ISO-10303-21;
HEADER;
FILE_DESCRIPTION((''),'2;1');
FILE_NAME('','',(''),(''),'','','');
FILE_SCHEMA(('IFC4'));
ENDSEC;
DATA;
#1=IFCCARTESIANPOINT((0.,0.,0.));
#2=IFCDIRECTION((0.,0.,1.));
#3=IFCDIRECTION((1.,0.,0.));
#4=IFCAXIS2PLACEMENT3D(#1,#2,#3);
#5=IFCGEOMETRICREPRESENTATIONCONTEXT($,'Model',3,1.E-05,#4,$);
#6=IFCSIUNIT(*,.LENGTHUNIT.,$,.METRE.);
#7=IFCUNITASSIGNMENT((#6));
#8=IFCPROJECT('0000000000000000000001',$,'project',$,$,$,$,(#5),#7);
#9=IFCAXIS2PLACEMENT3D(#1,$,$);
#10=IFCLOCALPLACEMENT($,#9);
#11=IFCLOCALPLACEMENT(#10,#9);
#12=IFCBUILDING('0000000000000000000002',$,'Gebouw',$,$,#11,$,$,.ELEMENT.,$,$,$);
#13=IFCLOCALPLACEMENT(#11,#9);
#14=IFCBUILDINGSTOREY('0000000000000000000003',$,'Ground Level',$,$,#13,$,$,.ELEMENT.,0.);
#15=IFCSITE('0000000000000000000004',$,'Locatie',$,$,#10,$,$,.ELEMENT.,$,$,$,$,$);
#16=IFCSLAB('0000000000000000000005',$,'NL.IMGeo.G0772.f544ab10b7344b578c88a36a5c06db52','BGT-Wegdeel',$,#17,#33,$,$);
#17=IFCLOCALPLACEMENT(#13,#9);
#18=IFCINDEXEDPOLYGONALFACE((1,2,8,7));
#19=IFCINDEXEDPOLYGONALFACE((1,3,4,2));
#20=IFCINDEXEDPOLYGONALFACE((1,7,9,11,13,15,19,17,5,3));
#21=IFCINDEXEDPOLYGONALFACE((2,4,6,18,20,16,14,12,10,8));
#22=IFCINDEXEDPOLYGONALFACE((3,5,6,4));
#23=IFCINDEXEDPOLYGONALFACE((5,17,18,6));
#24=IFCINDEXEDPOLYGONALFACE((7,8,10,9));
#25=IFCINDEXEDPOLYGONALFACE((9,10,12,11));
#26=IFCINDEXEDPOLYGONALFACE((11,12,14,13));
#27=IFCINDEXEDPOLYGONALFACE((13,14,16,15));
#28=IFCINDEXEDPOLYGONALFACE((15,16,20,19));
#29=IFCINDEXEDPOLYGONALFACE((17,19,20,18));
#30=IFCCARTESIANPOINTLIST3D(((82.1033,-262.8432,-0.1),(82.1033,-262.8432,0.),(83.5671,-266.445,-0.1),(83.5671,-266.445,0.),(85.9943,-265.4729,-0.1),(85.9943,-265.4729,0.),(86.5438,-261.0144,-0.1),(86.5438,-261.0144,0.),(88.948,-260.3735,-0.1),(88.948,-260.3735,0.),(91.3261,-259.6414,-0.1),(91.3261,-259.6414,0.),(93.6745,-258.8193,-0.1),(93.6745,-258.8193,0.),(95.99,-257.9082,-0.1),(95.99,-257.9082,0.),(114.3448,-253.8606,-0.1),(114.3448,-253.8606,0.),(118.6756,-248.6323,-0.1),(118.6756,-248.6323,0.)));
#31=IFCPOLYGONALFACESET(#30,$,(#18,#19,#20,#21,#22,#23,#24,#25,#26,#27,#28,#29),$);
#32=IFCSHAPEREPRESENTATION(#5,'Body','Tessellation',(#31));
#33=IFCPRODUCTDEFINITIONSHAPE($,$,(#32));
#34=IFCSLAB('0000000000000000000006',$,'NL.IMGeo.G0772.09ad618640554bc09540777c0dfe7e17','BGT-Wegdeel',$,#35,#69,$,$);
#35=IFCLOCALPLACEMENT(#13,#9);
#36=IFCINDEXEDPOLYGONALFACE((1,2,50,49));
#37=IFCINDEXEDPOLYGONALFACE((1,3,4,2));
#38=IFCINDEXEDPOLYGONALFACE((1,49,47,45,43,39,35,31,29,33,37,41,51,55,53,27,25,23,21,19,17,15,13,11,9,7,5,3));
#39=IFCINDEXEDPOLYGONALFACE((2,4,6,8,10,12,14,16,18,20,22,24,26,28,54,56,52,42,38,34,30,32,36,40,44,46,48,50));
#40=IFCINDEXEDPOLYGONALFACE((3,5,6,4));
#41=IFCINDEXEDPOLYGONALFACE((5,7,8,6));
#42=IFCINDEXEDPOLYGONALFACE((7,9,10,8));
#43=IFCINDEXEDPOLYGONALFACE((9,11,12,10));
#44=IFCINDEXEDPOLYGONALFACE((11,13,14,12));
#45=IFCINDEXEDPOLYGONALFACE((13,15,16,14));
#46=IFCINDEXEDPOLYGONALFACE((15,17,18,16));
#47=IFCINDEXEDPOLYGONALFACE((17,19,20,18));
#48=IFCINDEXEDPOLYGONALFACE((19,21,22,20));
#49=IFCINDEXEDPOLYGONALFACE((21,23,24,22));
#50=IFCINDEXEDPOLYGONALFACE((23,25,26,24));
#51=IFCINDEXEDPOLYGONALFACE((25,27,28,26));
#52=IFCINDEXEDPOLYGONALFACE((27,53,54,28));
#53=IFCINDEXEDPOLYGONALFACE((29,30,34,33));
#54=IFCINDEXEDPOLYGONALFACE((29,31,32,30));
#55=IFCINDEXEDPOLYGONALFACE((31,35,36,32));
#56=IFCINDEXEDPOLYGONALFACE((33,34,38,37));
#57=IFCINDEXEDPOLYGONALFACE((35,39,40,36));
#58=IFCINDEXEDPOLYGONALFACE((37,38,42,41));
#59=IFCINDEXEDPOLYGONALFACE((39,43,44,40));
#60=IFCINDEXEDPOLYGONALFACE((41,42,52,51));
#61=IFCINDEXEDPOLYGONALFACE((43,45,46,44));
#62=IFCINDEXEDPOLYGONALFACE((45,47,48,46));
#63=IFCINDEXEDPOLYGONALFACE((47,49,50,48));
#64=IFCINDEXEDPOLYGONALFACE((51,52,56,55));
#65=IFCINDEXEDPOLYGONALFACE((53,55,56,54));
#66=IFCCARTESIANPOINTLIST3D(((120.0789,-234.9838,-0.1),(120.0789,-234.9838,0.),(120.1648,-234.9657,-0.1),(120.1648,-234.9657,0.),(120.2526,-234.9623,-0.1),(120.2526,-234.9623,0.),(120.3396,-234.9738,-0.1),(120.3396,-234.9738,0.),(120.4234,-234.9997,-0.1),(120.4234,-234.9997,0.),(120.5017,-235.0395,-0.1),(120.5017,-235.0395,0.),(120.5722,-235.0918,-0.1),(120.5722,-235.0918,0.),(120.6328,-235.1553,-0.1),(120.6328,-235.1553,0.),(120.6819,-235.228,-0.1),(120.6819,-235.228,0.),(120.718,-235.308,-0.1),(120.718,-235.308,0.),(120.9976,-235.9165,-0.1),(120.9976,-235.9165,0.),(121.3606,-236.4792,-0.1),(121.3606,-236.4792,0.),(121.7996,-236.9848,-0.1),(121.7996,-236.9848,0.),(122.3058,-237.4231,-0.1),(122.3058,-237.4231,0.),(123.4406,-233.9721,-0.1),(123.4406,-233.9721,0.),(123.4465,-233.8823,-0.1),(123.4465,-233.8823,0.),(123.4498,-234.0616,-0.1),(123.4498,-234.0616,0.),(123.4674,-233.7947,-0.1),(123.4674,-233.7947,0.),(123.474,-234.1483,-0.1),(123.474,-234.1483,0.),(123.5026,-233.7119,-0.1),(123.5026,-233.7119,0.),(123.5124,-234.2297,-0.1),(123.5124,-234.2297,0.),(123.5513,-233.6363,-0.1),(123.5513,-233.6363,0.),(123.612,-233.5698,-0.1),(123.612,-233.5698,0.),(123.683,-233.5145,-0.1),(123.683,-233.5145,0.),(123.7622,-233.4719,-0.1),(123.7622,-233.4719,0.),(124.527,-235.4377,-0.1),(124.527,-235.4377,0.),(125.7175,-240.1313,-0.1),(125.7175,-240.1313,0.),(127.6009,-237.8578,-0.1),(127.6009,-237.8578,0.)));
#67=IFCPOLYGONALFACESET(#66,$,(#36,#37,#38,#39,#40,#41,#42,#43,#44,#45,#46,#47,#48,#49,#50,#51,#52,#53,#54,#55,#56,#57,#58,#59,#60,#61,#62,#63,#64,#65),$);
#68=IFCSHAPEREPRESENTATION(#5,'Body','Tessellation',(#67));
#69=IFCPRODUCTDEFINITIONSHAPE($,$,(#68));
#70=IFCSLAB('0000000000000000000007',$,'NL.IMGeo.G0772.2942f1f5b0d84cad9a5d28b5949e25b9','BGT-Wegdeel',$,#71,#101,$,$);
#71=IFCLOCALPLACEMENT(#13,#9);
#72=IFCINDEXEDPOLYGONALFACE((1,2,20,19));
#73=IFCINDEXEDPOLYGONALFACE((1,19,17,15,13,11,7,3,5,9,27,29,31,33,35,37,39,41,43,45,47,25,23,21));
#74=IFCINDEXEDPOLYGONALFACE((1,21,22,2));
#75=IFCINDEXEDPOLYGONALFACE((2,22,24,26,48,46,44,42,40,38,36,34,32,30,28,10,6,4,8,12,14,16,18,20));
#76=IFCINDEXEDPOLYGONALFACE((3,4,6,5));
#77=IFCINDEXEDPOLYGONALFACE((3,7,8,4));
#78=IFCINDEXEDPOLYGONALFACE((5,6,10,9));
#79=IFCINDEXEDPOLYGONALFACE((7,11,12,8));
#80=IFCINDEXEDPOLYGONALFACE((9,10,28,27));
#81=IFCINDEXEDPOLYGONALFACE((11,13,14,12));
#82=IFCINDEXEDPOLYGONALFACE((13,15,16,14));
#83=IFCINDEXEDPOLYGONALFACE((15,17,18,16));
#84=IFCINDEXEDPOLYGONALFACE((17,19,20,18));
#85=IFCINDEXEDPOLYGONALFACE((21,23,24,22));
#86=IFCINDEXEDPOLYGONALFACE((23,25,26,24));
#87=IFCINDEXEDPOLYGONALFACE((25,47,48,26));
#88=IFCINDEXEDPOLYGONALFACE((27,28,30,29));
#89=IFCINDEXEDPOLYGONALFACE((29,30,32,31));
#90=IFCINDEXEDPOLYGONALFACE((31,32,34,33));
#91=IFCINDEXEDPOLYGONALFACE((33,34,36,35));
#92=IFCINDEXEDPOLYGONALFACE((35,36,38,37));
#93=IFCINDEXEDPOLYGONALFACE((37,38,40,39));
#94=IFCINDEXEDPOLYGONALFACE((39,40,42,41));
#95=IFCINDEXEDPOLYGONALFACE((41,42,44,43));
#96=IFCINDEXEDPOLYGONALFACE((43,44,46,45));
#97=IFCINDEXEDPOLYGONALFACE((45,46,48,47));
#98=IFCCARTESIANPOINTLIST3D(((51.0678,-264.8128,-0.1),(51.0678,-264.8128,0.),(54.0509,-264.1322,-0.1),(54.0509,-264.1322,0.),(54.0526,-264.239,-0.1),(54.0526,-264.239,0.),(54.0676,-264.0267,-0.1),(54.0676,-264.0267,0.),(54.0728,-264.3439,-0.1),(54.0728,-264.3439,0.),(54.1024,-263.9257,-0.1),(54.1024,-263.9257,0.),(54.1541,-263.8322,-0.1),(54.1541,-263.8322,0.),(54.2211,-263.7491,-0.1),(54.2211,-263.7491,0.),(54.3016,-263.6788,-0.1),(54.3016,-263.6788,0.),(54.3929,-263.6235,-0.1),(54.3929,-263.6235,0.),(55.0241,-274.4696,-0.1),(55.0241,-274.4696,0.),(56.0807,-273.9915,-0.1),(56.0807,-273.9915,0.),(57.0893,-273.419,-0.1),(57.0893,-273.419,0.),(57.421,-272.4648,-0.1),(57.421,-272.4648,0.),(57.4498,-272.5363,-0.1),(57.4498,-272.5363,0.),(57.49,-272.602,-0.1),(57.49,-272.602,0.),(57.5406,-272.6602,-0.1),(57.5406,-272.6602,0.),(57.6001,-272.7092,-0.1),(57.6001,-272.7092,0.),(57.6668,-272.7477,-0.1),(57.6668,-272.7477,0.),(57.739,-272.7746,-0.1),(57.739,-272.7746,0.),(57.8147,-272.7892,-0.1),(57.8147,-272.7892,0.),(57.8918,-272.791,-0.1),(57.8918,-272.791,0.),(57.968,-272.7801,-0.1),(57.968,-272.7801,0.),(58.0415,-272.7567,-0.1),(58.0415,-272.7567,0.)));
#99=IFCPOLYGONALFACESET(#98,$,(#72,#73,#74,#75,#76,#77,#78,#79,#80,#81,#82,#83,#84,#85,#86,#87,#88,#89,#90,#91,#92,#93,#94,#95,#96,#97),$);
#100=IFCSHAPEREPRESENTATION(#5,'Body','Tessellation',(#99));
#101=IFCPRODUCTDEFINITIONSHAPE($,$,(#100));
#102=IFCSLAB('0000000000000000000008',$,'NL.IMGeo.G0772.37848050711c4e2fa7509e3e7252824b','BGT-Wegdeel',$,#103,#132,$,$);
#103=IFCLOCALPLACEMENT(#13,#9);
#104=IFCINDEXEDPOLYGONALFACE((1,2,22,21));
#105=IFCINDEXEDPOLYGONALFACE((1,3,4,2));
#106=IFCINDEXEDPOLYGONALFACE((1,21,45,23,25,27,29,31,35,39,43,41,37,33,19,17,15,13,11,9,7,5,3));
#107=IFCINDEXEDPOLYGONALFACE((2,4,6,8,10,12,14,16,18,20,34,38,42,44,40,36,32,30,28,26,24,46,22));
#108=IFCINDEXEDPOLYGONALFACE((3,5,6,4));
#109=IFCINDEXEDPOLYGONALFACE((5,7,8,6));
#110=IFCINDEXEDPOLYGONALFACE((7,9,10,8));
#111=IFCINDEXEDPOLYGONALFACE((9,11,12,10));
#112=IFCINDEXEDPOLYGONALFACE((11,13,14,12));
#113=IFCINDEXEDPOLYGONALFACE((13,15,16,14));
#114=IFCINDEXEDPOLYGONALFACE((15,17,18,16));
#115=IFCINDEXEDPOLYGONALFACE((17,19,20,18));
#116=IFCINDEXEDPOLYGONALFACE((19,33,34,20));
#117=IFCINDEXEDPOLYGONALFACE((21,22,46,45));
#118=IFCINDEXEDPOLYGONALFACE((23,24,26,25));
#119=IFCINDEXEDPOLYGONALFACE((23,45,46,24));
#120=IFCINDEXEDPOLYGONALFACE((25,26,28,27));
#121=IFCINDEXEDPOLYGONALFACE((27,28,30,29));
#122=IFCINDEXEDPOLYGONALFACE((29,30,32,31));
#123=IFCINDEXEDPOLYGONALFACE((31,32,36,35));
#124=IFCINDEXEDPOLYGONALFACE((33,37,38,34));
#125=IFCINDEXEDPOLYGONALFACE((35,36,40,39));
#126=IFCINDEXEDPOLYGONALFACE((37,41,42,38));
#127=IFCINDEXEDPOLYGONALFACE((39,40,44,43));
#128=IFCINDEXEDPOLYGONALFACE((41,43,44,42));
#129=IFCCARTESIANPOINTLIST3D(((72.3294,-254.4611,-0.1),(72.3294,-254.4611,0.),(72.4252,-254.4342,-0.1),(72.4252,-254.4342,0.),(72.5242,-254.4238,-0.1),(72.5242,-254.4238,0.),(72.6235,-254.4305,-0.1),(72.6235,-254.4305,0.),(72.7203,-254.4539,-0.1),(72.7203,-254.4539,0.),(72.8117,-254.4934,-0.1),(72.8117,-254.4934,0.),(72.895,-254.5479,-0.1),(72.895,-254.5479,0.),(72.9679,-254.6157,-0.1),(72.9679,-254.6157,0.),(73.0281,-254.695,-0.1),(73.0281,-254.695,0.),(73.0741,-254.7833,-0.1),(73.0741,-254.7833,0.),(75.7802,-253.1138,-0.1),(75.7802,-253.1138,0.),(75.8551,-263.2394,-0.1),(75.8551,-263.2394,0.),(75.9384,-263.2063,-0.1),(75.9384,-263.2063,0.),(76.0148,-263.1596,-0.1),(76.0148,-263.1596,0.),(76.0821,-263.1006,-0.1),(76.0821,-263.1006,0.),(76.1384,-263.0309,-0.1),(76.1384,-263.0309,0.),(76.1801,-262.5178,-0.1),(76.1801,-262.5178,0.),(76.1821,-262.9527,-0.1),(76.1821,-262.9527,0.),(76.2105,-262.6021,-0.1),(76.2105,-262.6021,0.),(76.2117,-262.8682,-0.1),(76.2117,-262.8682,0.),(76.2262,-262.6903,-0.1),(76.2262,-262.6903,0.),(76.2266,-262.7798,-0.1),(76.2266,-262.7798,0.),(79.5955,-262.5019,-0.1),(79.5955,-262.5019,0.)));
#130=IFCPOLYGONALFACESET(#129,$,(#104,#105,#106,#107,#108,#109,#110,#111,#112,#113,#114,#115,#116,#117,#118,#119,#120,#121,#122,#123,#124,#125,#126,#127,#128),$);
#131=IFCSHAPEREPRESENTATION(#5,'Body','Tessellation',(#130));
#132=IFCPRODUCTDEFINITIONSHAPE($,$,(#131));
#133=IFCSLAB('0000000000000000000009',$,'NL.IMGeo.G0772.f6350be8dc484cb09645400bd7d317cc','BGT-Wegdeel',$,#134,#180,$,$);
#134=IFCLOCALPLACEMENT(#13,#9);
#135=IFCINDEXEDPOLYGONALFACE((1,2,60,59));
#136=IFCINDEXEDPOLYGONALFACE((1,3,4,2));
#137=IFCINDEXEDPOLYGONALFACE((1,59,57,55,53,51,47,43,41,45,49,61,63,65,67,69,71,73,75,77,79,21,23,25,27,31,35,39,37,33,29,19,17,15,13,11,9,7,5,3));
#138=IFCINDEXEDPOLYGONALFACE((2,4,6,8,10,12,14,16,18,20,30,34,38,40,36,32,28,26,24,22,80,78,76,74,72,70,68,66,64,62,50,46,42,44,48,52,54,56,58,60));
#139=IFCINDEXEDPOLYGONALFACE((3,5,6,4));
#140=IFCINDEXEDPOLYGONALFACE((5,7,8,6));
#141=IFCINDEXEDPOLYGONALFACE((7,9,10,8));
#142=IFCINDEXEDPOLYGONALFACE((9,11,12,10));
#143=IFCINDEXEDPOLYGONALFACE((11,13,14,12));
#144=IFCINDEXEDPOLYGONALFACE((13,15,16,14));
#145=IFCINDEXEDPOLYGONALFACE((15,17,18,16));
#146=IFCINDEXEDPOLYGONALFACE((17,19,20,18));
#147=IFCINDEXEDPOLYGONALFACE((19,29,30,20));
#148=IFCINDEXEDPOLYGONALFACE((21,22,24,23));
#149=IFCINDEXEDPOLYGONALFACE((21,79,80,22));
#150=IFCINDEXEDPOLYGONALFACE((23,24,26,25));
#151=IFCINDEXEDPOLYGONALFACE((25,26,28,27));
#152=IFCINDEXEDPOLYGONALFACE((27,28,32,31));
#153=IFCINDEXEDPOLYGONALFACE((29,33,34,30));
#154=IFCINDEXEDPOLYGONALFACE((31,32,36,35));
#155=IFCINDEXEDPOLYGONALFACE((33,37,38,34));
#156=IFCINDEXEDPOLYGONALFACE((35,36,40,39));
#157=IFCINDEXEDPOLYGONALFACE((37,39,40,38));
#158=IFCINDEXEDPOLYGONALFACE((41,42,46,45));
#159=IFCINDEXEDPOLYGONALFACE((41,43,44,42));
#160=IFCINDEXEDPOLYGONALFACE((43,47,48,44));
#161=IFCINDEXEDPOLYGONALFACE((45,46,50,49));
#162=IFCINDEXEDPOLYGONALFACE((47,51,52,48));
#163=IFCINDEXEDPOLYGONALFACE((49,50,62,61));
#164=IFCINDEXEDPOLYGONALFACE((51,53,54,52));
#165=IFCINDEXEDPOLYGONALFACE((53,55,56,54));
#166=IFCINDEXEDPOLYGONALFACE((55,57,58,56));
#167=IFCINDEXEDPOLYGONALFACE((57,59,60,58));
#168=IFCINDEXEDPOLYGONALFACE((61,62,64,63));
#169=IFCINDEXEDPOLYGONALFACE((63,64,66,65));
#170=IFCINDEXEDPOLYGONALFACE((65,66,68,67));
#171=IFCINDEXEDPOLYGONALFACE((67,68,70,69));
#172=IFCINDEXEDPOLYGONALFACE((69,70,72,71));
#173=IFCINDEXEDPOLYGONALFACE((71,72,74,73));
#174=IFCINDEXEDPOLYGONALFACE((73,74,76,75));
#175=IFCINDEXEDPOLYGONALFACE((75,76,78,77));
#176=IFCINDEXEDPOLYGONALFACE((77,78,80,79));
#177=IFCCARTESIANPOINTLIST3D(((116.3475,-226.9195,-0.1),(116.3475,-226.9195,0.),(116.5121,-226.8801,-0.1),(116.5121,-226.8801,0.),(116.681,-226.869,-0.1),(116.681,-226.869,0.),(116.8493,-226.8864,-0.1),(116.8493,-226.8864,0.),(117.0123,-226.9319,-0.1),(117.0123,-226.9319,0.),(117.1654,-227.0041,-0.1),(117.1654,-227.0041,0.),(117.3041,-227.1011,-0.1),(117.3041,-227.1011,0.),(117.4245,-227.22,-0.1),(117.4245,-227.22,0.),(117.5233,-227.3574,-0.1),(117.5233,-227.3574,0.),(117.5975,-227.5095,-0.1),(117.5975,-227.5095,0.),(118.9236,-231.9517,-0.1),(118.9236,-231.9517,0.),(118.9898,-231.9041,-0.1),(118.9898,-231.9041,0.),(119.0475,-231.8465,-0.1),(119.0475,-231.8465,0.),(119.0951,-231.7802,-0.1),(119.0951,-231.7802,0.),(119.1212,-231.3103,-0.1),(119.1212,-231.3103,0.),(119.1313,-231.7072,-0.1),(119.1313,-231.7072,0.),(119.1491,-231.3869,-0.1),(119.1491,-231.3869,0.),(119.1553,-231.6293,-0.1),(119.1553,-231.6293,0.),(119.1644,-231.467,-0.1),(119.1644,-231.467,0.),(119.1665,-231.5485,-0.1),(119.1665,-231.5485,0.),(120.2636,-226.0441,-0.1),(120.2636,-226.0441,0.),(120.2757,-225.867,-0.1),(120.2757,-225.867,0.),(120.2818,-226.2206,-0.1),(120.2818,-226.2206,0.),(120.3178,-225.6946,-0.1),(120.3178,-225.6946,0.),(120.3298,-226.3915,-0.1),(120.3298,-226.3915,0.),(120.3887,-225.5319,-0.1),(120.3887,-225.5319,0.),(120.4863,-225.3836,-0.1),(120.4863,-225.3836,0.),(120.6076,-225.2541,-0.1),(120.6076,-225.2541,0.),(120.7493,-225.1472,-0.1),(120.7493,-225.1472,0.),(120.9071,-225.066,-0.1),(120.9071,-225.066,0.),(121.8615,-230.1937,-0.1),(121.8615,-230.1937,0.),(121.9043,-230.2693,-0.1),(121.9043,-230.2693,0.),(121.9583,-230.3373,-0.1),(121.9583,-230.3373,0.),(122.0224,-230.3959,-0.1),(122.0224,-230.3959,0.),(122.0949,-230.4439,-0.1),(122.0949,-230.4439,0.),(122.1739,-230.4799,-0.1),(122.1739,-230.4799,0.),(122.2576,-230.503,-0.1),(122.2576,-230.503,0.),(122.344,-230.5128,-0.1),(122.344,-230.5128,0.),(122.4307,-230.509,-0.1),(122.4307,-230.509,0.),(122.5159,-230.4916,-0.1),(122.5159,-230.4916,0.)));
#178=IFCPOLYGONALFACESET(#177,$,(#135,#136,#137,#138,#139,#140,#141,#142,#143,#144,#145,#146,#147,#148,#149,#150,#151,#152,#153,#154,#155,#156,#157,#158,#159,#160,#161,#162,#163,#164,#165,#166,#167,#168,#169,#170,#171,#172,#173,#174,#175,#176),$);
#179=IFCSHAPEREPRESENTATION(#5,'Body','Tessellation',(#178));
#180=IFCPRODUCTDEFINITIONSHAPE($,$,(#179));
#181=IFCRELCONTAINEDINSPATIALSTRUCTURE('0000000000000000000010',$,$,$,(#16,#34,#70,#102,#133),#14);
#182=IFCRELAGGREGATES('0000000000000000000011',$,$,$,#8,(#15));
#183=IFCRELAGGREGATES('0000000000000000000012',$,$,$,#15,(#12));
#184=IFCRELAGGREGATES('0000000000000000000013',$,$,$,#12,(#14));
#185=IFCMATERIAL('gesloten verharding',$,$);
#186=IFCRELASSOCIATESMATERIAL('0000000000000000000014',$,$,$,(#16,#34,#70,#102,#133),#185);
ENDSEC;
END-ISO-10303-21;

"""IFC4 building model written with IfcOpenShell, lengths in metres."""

from ifc_helpers import new_model, si_unit, frame, origin, origin_with_axes, place, context, project, spatial, polyline, outline, extrude, material, element, save


model = new_model("IFC4")

# Units and contexts
model_context = context("Model", 3, precision=1e-05, world=origin_with_axes())
ifc_project = project(units=[si_unit("LENGTHUNIT", "METRE")], contexts=[model_context])

# Site, building, storey
site_placement = place(None, origin())
site = spatial("IfcSite", under=ifc_project, at=site_placement, Name="Locatie", CompositionType="ELEMENT")
building_placement = place(site_placement, origin())
building = spatial("IfcBuilding", under=site, at=building_placement, Name="Gebouw", CompositionType="ELEMENT")
storey_placement = place(building_placement, origin())
storey = spatial("IfcBuildingStorey", under=building, at=storey_placement, Name="Ground Level", CompositionType="ELEMENT", Elevation=0.0)

# Slabs
ifc_material_1 = material(Name="gesloten verharding")
slab_1_placement = place(storey_placement, origin())
element("IfcSlab", 1, at=slab_1_placement, inside=storey, material=ifc_material_1, Name="NL.IMGeo.G0772.f544ab10b7344b578c88a36a5c06db52", Description="BGT-Wegdeel", context=model_context, shape_type="SweptSolid", body=[
    extrude(outline(polyline([(85.9943, -265.4729), (83.5671, -266.445), (82.1033, -262.8432), (86.5438, -261.0144), (88.948, -260.3735), (91.3261, -259.6414), (93.6745, -258.8193), (95.99, -257.9082), (118.6756, -248.6323), (114.3448, -253.8606), (85.9943, -265.4729)])), frame((0.0, 0.0, -0.1), z_axis=(0.0, 0.0, 1.0), x_axis=(1.0, 0.0, 0.0)), (0.0, 0.0, 1.0), 0.1),
])
slab_2_placement = place(storey_placement, origin())
element("IfcSlab", 2, at=slab_2_placement, inside=storey, material=ifc_material_1, Name="NL.IMGeo.G0772.09ad618640554bc09540777c0dfe7e17", Description="BGT-Wegdeel", context=model_context, shape_type="SweptSolid", body=[
    extrude(outline(polyline([(122.3058, -237.4231), (121.7996, -236.9848), (121.3606, -236.4792), (120.9976, -235.9165), (120.718, -235.308), (120.6819, -235.228), (120.6328, -235.1553), (120.5722, -235.0918), (120.5017, -235.0395), (120.4234, -234.9997), (120.3396, -234.9738), (120.2526, -234.9623), (120.1648, -234.9657), (120.0789, -234.9838), (123.7622, -233.4719), (123.683, -233.5145), (123.612, -233.5698), (123.5513, -233.6363), (123.5026, -233.7119), (123.4674, -233.7947), (123.4465, -233.8823), (123.4406, -233.9721), (123.4498, -234.0616), (123.474, -234.1483), (123.5124, -234.2297), (124.527, -235.4377), (127.6009, -237.8578), (125.7175, -240.1313), (122.3058, -237.4231)])), frame((0.0, 0.0, -0.1), z_axis=(0.0, 0.0, 1.0), x_axis=(1.0, 0.0, 0.0)), (0.0, 0.0, 1.0), 0.1),
])
slab_3_placement = place(storey_placement, origin())
element("IfcSlab", 3, at=slab_3_placement, inside=storey, material=ifc_material_1, Name="NL.IMGeo.G0772.2942f1f5b0d84cad9a5d28b5949e25b9", Description="BGT-Wegdeel", context=model_context, shape_type="SweptSolid", body=[
    extrude(outline(polyline([(57.421, -272.4648), (57.4498, -272.5363), (57.49, -272.602), (57.5406, -272.6602), (57.6001, -272.7092), (57.6668, -272.7477), (57.739, -272.7746), (57.8147, -272.7892), (57.8918, -272.791), (57.968, -272.7801), (58.0415, -272.7567), (57.0893, -273.419), (56.0807, -273.9915), (55.0241, -274.4696), (51.0678, -264.8128), (54.3929, -263.6235), (54.3016, -263.6788), (54.2211, -263.7491), (54.1541, -263.8322), (54.1024, -263.9257), (54.0676, -264.0267), (54.0509, -264.1322), (54.0526, -264.239), (54.0728, -264.3439), (57.421, -272.4648)])), frame((0.0, 0.0, -0.1), z_axis=(0.0, 0.0, 1.0), x_axis=(1.0, 0.0, 0.0)), (0.0, 0.0, 1.0), 0.1),
])
slab_4_placement = place(storey_placement, origin())
element("IfcSlab", 4, at=slab_4_placement, inside=storey, material=ifc_material_1, Name="NL.IMGeo.G0772.37848050711c4e2fa7509e3e7252824b", Description="BGT-Wegdeel", context=model_context, shape_type="SweptSolid", body=[
    extrude(outline(polyline([(79.5955, -262.5019), (75.8551, -263.2394), (75.9384, -263.2063), (76.0148, -263.1596), (76.0821, -263.1006), (76.1384, -263.0309), (76.1821, -262.9527), (76.2117, -262.8682), (76.2266, -262.7798), (76.2262, -262.6903), (76.2105, -262.6021), (76.1801, -262.5178), (73.0741, -254.7833), (73.0281, -254.695), (72.9679, -254.6157), (72.895, -254.5479), (72.8117, -254.4934), (72.7203, -254.4539), (72.6235, -254.4305), (72.5242, -254.4238), (72.4252, -254.4342), (72.3294, -254.4611), (75.7802, -253.1138), (79.5955, -262.5019)])), frame((0.0, 0.0, -0.1), z_axis=(0.0, 0.0, 1.0), x_axis=(1.0, 0.0, 0.0)), (0.0, 0.0, 1.0), 0.1),
])
slab_5_placement = place(storey_placement, origin())
element("IfcSlab", 5, at=slab_5_placement, inside=storey, material=ifc_material_1, Name="NL.IMGeo.G0772.f6350be8dc484cb09645400bd7d317cc", Description="BGT-Wegdeel", context=model_context, shape_type="SweptSolid", body=[
    extrude(outline(polyline([(121.8615, -230.1937), (121.9043, -230.2693), (121.9583, -230.3373), (122.0224, -230.3959), (122.0949, -230.4439), (122.1739, -230.4799), (122.2576, -230.503), (122.344, -230.5128), (122.4307, -230.509), (122.5159, -230.4916), (118.9236, -231.9517), (118.9898, -231.9041), (119.0475, -231.8465), (119.0951, -231.7802), (119.1313, -231.7072), (119.1553, -231.6293), (119.1665, -231.5485), (119.1644, -231.467), (119.1491, -231.3869), (119.1212, -231.3103), (117.5975, -227.5095), (117.5233, -227.3574), (117.4245, -227.22), (117.3041, -227.1011), (117.1654, -227.0041), (117.0123, -226.9319), (116.8493, -226.8864), (116.681, -226.869), (116.5121, -226.8801), (116.3475, -226.9195), (120.9071, -225.066), (120.7493, -225.1472), (120.6076, -225.2541), (120.4863, -225.3836), (120.3887, -225.5319), (120.3178, -225.6946), (120.2757, -225.867), (120.2636, -226.0441), (120.2818, -226.2206), (120.3298, -226.3915), (121.8615, -230.1937)])), frame((0.0, 0.0, -0.1), z_axis=(0.0, 0.0, 1.0), x_axis=(1.0, 0.0, 0.0)), (0.0, 0.0, 1.0), 0.1),
])

save(model, "model.ifc")
